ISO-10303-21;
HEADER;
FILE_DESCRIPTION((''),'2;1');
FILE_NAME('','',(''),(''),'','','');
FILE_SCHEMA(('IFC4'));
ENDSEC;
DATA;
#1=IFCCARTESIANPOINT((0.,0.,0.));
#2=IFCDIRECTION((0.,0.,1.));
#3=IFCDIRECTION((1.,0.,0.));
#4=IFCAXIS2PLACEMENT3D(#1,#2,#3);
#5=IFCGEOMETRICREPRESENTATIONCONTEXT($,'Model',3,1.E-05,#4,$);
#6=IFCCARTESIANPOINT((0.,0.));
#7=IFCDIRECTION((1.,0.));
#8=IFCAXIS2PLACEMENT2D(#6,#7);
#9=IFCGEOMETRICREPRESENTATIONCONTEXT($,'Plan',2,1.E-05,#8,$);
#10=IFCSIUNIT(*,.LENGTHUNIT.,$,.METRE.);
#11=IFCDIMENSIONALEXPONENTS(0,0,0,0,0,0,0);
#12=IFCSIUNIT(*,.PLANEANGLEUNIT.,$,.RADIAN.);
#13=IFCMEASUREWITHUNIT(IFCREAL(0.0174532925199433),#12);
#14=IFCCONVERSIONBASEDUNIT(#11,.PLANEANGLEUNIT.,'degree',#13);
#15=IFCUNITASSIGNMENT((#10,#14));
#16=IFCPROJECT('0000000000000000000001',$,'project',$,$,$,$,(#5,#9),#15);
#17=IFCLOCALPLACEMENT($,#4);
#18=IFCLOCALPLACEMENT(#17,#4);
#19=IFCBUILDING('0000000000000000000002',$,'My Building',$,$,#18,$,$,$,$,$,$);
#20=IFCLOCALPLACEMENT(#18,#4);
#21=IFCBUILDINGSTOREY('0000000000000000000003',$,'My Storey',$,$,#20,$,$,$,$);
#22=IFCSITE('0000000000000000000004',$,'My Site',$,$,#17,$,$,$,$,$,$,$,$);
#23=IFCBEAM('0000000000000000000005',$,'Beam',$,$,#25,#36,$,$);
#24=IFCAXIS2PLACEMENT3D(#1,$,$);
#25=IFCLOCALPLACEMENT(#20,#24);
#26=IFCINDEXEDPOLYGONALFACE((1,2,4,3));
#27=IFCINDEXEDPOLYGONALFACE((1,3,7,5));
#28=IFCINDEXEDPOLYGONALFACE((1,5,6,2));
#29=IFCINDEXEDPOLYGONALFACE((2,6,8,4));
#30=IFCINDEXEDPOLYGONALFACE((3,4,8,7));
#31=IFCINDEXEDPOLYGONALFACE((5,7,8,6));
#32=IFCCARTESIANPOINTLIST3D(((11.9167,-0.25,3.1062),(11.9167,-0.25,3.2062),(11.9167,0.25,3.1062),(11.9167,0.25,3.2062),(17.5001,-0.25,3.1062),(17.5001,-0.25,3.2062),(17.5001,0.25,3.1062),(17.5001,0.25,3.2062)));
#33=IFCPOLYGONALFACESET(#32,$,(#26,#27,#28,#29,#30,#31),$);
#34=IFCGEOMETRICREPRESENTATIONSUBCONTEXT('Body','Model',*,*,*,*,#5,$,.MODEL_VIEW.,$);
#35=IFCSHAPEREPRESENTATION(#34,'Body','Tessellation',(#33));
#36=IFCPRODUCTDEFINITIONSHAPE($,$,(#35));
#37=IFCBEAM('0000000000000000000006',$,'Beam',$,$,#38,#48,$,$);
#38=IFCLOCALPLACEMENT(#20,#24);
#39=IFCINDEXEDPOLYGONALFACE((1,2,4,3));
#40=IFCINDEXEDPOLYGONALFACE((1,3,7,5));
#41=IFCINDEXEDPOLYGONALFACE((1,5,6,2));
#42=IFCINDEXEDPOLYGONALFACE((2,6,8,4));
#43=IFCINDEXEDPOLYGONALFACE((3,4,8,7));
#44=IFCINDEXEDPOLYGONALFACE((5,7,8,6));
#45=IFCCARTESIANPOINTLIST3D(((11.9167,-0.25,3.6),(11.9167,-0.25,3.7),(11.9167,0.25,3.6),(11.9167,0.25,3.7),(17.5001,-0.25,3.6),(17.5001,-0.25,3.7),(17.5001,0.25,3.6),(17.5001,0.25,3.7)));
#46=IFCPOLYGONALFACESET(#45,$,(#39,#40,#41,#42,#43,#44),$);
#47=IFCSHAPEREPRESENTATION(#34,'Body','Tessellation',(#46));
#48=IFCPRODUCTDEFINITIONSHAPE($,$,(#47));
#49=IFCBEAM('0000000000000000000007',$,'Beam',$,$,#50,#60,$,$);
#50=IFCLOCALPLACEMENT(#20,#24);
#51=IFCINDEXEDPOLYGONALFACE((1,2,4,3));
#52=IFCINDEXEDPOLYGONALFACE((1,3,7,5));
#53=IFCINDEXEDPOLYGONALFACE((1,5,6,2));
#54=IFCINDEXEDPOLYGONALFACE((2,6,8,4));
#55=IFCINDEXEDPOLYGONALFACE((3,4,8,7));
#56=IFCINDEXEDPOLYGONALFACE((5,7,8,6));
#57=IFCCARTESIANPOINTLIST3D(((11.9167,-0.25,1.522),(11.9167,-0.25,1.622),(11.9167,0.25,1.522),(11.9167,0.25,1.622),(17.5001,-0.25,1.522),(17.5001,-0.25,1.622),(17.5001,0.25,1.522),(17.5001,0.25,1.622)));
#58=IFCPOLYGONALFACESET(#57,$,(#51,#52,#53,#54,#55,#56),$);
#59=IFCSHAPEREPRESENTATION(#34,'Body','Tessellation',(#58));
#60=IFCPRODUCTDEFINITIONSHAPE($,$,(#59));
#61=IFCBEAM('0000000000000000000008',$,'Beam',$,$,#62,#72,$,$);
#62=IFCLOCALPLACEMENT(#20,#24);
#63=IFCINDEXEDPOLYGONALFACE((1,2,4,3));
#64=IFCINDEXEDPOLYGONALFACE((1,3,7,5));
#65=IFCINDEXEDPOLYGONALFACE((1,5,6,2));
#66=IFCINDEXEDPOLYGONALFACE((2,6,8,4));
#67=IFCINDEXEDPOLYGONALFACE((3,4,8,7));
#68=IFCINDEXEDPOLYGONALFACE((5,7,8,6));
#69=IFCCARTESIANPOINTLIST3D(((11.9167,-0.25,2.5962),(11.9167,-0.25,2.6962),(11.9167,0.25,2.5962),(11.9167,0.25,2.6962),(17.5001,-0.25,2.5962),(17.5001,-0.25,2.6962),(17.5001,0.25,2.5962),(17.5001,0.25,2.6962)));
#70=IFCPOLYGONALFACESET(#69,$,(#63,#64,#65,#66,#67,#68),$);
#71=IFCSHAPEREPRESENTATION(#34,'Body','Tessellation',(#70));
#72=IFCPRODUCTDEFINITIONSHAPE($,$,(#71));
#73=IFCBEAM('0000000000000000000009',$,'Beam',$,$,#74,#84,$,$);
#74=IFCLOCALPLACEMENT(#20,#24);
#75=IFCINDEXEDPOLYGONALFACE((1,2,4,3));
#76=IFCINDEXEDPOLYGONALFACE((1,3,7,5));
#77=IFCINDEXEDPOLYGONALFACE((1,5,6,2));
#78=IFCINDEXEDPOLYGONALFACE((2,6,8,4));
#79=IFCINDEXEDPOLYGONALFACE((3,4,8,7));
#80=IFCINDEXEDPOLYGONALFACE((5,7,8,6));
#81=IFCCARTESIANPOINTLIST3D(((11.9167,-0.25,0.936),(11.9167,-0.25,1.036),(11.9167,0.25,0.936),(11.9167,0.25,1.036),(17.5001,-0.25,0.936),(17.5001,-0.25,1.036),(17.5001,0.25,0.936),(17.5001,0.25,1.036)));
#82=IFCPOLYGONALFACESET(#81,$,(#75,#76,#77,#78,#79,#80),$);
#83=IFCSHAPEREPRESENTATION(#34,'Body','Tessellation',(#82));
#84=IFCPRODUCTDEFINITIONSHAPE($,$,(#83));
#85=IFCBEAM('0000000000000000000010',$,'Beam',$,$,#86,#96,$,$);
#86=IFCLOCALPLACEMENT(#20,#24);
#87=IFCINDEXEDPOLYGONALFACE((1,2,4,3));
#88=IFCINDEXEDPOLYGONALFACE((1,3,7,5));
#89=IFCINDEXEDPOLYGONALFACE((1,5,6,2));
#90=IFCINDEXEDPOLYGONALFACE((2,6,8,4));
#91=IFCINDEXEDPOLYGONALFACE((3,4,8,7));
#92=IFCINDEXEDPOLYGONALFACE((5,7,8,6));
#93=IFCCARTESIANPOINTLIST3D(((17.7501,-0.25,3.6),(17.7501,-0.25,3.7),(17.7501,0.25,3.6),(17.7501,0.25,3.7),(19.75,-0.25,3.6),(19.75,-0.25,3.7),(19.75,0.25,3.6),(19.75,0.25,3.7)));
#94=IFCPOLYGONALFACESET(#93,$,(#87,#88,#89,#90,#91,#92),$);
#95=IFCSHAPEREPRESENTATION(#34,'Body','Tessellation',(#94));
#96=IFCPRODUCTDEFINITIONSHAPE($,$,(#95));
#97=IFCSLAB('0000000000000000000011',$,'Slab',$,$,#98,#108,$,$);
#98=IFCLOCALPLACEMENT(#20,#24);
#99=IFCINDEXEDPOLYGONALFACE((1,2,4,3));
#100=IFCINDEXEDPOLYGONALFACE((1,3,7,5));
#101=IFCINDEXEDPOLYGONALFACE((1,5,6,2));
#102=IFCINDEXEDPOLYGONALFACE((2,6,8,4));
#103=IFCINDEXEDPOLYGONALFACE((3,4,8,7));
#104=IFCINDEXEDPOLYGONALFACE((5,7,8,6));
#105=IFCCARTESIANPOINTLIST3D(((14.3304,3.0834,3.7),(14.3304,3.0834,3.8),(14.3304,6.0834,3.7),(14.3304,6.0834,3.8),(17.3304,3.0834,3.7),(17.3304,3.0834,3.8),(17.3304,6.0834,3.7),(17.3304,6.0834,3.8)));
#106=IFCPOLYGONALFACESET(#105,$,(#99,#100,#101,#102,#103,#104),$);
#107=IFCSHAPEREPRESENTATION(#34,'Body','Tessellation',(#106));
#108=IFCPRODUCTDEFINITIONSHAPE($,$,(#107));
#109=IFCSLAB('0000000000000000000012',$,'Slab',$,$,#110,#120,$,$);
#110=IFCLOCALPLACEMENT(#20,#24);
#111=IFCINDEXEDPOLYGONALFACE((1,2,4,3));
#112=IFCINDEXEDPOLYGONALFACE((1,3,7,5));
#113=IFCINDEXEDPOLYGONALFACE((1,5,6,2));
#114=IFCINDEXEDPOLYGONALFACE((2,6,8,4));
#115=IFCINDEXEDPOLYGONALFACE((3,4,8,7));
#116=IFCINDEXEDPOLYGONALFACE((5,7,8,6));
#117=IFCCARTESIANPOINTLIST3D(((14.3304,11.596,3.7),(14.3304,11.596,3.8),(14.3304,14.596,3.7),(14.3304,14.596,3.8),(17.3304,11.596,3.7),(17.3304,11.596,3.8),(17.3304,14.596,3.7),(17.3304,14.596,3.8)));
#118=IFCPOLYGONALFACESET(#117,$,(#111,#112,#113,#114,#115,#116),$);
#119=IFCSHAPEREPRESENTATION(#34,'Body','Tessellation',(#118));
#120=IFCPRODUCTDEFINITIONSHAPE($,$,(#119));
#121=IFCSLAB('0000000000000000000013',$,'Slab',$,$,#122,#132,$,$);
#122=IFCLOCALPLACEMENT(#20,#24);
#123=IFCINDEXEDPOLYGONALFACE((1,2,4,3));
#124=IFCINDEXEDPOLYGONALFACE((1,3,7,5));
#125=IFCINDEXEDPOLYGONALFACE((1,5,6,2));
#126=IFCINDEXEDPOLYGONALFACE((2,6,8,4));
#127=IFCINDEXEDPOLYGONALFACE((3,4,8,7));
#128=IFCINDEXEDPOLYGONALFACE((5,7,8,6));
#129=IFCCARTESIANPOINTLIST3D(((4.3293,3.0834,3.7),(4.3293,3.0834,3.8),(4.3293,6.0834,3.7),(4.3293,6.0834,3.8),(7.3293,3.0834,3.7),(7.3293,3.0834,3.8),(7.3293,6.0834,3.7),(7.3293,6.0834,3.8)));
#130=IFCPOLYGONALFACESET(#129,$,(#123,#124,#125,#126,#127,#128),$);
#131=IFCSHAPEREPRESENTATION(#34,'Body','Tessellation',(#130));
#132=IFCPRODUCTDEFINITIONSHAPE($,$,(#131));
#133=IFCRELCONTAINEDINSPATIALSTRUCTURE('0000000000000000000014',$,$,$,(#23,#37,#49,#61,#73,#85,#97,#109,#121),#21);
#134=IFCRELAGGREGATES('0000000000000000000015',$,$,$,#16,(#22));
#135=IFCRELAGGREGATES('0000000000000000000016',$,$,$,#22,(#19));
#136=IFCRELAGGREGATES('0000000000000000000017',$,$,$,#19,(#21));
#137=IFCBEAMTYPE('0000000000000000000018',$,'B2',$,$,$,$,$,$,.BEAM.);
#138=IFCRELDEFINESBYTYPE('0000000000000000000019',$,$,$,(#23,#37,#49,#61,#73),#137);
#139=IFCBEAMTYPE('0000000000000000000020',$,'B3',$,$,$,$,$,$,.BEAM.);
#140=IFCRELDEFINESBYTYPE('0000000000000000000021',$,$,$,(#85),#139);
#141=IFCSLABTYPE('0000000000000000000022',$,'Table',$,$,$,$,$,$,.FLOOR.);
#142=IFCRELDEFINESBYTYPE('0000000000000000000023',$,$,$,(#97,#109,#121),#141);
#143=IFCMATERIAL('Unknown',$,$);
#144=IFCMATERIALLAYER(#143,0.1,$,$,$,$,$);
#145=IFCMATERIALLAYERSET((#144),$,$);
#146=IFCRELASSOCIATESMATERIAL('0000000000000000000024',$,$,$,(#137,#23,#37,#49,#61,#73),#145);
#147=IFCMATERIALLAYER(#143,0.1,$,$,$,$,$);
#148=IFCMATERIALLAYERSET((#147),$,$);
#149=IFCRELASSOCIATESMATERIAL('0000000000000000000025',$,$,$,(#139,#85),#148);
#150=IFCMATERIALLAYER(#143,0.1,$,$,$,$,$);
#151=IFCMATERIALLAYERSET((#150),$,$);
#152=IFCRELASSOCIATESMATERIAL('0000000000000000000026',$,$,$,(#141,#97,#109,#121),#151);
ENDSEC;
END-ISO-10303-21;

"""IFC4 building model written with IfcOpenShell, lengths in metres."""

from ifc_helpers import new_model, entity, si_unit, converted_unit, frame, origin_with_axes, origin_2d_with_axis, place, context, subcontext, project, spatial, indexed_curve, outline, extrude, material, layer, layer_set, layer_usage, type_object, element, save


model = new_model("IFC4")

# Units and contexts
model_context = context("Model", 3, precision=1e-05, world=origin_with_axes())
plan_context = context("Plan", 2, precision=1e-05, world=origin_2d_with_axis())
body_context = subcontext(model_context, "Body", "Model", "MODEL_VIEW")
ifc_project = project(units=[si_unit("LENGTHUNIT", "METRE"), converted_unit("PLANEANGLEUNIT", "degree", entity("IfcReal", 0.0174532925199433), si_unit("PLANEANGLEUNIT", "RADIAN"), dimensions=[0, 0, 0, 0, 0, 0, 0])], contexts=[model_context, plan_context])

# Site, building, storey
site_placement = place(None, origin_with_axes())
site = spatial("IfcSite", under=ifc_project, at=site_placement, Name="My Site")
building_placement = place(site_placement, origin_with_axes())
building = spatial("IfcBuilding", under=site, at=building_placement, Name="My Building")
storey_placement = place(building_placement, origin_with_axes())
storey = spatial("IfcBuildingStorey", under=building, at=storey_placement, Name="My Storey")

# Shared definitions
ifc_material = material(Name="Unknown")

# Beams
ifc_layer_1 = layer(ifc_material, 0.1)
ifc_layer_set_1 = layer_set([ifc_layer_1])
beam_type_1 = type_object("IfcBeamType", Name="B2", PredefinedType="BEAM", material=ifc_layer_set_1)
ifc_layer_usage_1 = layer_usage(ifc_layer_set_1, "AXIS3", "POSITIVE", -0.1)
beam_1_placement = place(storey_placement, frame((11.9167, 0.25, 3.2062), z_axis=(0.0, 0.0, 1.0), x_axis=(1.0, 0.0, 0.0)))
element("IfcBeam", 1, at=beam_1_placement, inside=storey, type_object=beam_type_1, material=ifc_layer_usage_1, Name="Beam", context=body_context, shape_type="SweptSolid", body=[
    extrude(outline(indexed_curve([(0.0, 0.0), (0.0, -0.5), (5.5833, -0.5), (5.5834, 0.0), (0.0, 0.0)])), frame((0.0, 0.0, -0.1), z_axis=(0.0, 0.0, 1.0), x_axis=(1.0, 0.0, 0.0)), (0.0, 0.0, 1.0), 0.1),
])
ifc_layer_usage_2 = layer_usage(ifc_layer_set_1, "AXIS3", "POSITIVE", -0.1)
beam_2_placement = place(storey_placement, frame((11.9167, 0.25, 3.7), z_axis=(0.0, 0.0, 1.0), x_axis=(1.0, 0.0, 0.0)))
element("IfcBeam", 2, at=beam_2_placement, inside=storey, type_object=beam_type_1, material=ifc_layer_usage_2, Name="Beam", context=body_context, shape_type="SweptSolid", body=[
    extrude(outline(indexed_curve([(0.0, 0.0), (0.0, -0.5), (5.5833, -0.5), (5.5834, 0.0), (0.0, 0.0)])), frame((0.0, 0.0, -0.1), z_axis=(0.0, 0.0, 1.0), x_axis=(1.0, 0.0, 0.0)), (0.0, 0.0, 1.0), 0.1),
])
ifc_layer_usage_3 = layer_usage(ifc_layer_set_1, "AXIS3", "POSITIVE", -0.1)
beam_3_placement = place(storey_placement, frame((11.9167, 0.25, 1.622), z_axis=(0.0, 0.0, 1.0), x_axis=(1.0, 0.0, 0.0)))
element("IfcBeam", 3, at=beam_3_placement, inside=storey, type_object=beam_type_1, material=ifc_layer_usage_3, Name="Beam", context=body_context, shape_type="SweptSolid", body=[
    extrude(outline(indexed_curve([(0.0, 0.0), (0.0, -0.5), (5.5833, -0.5), (5.5834, 0.0), (0.0, 0.0)])), frame((0.0, 0.0, -0.1), z_axis=(0.0, 0.0, 1.0), x_axis=(1.0, 0.0, 0.0)), (0.0, 0.0, 1.0), 0.1),
])
ifc_layer_usage_4 = layer_usage(ifc_layer_set_1, "AXIS3", "POSITIVE", -0.1)
beam_4_placement = place(storey_placement, frame((11.9167, 0.25, 2.6962), z_axis=(0.0, 0.0, 1.0), x_axis=(1.0, 0.0, 0.0)))
element("IfcBeam", 4, at=beam_4_placement, inside=storey, type_object=beam_type_1, material=ifc_layer_usage_4, Name="Beam", context=body_context, shape_type="SweptSolid", body=[
    extrude(outline(indexed_curve([(0.0, 0.0), (0.0, -0.5), (5.5833, -0.5), (5.5834, 0.0), (0.0, 0.0)])), frame((0.0, 0.0, -0.1), z_axis=(0.0, 0.0, 1.0), x_axis=(1.0, 0.0, 0.0)), (0.0, 0.0, 1.0), 0.1),
])
ifc_layer_usage_5 = layer_usage(ifc_layer_set_1, "AXIS3", "POSITIVE", -0.1)
beam_5_placement = place(storey_placement, frame((11.9167, 0.25, 1.036), z_axis=(0.0, 0.0, 1.0), x_axis=(1.0, 0.0, 0.0)))
element("IfcBeam", 5, at=beam_5_placement, inside=storey, type_object=beam_type_1, material=ifc_layer_usage_5, Name="Beam", context=body_context, shape_type="SweptSolid", body=[
    extrude(outline(indexed_curve([(0.0, 0.0), (0.0, -0.5), (5.5833, -0.5), (5.5834, 0.0), (0.0, 0.0)])), frame((0.0, 0.0, -0.1), z_axis=(0.0, 0.0, 1.0), x_axis=(1.0, 0.0, 0.0)), (0.0, 0.0, 1.0), 0.1),
])
ifc_layer_2 = layer(ifc_material, 0.1)
ifc_layer_set_2 = layer_set([ifc_layer_2])
ifc_layer_usage_6 = layer_usage(ifc_layer_set_2, "AXIS3", "POSITIVE", -0.1)
beam_type_2 = type_object("IfcBeamType", Name="B3", PredefinedType="BEAM", material=ifc_layer_set_2)
beam_6_placement = place(storey_placement, frame((17.7501, -0.25, 3.7), z_axis=(0.0, 0.0, 1.0), x_axis=(1.0, 0.0, 0.0)))
element("IfcBeam", 6, at=beam_6_placement, inside=storey, type_object=beam_type_2, material=ifc_layer_usage_6, Name="Beam", context=body_context, shape_type="SweptSolid", body=[
    extrude(outline(indexed_curve([(0.0, 0.0), (0.0, 0.5), (1.9999, 0.5), (1.9999, 0.0), (0.0, 0.0)])), frame((0.0, 0.0, -0.1), z_axis=(0.0, 0.0, 1.0), x_axis=(1.0, 0.0, 0.0)), (0.0, 0.0, 1.0), 0.1),
])

# Slabs
ifc_layer_3 = layer(ifc_material, 0.1)
ifc_layer_set_3 = layer_set([ifc_layer_3])
ifc_layer_usage_7 = layer_usage(ifc_layer_set_3, "AXIS3", "POSITIVE", -0.1)
slab_type = type_object("IfcSlabType", Name="Table", PredefinedType="FLOOR", material=ifc_layer_set_3)
slab_1_placement = place(storey_placement, frame((14.3304, 3.0834, 3.8), z_axis=(0.0, 0.0, 1.0), x_axis=(1.0, 0.0, 0.0)))
element("IfcSlab", 7, at=slab_1_placement, inside=storey, type_object=slab_type, material=ifc_layer_usage_7, Name="Slab", context=body_context, shape_type="SweptSolid", body=[
    extrude(outline(indexed_curve([(0.0, 0.0), (3.0, 0.0), (3.0, 3.0), (0.0, 3.0), (0.0, 0.0), (0.0, 0.0)])), frame((0.0, 0.0, -0.1), z_axis=(0.0, 0.0, 1.0), x_axis=(1.0, 0.0, 0.0)), (0.0, 0.0, 1.0), 0.1),
])
ifc_layer_usage_8 = layer_usage(ifc_layer_set_3, "AXIS3", "POSITIVE", -0.1)
slab_2_placement = place(storey_placement, frame((14.3304, 11.596, 3.8), z_axis=(0.0, 0.0, 1.0), x_axis=(1.0, 0.0, 0.0)))
element("IfcSlab", 8, at=slab_2_placement, inside=storey, type_object=slab_type, material=ifc_layer_usage_8, Name="Slab", context=body_context, shape_type="SweptSolid", body=[
    extrude(outline(indexed_curve([(0.0, 0.0), (3.0, 0.0), (3.0, 3.0), (0.0, 3.0), (0.0, 0.0), (0.0, 0.0)])), frame((0.0, 0.0, -0.1), z_axis=(0.0, 0.0, 1.0), x_axis=(1.0, 0.0, 0.0)), (0.0, 0.0, 1.0), 0.1),
])
ifc_layer_usage_9 = layer_usage(ifc_layer_set_3, "AXIS3", "POSITIVE", -0.1)
slab_3_placement = place(storey_placement, frame((4.3293, 3.0834, 3.8), z_axis=(0.0, 0.0, 1.0), x_axis=(1.0, 0.0, 0.0)))
element("IfcSlab", 9, at=slab_3_placement, inside=storey, type_object=slab_type, material=ifc_layer_usage_9, Name="Slab", context=body_context, shape_type="SweptSolid", body=[
    extrude(outline(indexed_curve([(0.0, 0.0), (3.0, 0.0), (3.0, 3.0), (0.0, 3.0), (0.0, 0.0), (0.0, 0.0)])), frame((0.0, 0.0, -0.1), z_axis=(0.0, 0.0, 1.0), x_axis=(1.0, 0.0, 0.0)), (0.0, 0.0, 1.0), 0.1),
])

save(model, "model.ifc")
